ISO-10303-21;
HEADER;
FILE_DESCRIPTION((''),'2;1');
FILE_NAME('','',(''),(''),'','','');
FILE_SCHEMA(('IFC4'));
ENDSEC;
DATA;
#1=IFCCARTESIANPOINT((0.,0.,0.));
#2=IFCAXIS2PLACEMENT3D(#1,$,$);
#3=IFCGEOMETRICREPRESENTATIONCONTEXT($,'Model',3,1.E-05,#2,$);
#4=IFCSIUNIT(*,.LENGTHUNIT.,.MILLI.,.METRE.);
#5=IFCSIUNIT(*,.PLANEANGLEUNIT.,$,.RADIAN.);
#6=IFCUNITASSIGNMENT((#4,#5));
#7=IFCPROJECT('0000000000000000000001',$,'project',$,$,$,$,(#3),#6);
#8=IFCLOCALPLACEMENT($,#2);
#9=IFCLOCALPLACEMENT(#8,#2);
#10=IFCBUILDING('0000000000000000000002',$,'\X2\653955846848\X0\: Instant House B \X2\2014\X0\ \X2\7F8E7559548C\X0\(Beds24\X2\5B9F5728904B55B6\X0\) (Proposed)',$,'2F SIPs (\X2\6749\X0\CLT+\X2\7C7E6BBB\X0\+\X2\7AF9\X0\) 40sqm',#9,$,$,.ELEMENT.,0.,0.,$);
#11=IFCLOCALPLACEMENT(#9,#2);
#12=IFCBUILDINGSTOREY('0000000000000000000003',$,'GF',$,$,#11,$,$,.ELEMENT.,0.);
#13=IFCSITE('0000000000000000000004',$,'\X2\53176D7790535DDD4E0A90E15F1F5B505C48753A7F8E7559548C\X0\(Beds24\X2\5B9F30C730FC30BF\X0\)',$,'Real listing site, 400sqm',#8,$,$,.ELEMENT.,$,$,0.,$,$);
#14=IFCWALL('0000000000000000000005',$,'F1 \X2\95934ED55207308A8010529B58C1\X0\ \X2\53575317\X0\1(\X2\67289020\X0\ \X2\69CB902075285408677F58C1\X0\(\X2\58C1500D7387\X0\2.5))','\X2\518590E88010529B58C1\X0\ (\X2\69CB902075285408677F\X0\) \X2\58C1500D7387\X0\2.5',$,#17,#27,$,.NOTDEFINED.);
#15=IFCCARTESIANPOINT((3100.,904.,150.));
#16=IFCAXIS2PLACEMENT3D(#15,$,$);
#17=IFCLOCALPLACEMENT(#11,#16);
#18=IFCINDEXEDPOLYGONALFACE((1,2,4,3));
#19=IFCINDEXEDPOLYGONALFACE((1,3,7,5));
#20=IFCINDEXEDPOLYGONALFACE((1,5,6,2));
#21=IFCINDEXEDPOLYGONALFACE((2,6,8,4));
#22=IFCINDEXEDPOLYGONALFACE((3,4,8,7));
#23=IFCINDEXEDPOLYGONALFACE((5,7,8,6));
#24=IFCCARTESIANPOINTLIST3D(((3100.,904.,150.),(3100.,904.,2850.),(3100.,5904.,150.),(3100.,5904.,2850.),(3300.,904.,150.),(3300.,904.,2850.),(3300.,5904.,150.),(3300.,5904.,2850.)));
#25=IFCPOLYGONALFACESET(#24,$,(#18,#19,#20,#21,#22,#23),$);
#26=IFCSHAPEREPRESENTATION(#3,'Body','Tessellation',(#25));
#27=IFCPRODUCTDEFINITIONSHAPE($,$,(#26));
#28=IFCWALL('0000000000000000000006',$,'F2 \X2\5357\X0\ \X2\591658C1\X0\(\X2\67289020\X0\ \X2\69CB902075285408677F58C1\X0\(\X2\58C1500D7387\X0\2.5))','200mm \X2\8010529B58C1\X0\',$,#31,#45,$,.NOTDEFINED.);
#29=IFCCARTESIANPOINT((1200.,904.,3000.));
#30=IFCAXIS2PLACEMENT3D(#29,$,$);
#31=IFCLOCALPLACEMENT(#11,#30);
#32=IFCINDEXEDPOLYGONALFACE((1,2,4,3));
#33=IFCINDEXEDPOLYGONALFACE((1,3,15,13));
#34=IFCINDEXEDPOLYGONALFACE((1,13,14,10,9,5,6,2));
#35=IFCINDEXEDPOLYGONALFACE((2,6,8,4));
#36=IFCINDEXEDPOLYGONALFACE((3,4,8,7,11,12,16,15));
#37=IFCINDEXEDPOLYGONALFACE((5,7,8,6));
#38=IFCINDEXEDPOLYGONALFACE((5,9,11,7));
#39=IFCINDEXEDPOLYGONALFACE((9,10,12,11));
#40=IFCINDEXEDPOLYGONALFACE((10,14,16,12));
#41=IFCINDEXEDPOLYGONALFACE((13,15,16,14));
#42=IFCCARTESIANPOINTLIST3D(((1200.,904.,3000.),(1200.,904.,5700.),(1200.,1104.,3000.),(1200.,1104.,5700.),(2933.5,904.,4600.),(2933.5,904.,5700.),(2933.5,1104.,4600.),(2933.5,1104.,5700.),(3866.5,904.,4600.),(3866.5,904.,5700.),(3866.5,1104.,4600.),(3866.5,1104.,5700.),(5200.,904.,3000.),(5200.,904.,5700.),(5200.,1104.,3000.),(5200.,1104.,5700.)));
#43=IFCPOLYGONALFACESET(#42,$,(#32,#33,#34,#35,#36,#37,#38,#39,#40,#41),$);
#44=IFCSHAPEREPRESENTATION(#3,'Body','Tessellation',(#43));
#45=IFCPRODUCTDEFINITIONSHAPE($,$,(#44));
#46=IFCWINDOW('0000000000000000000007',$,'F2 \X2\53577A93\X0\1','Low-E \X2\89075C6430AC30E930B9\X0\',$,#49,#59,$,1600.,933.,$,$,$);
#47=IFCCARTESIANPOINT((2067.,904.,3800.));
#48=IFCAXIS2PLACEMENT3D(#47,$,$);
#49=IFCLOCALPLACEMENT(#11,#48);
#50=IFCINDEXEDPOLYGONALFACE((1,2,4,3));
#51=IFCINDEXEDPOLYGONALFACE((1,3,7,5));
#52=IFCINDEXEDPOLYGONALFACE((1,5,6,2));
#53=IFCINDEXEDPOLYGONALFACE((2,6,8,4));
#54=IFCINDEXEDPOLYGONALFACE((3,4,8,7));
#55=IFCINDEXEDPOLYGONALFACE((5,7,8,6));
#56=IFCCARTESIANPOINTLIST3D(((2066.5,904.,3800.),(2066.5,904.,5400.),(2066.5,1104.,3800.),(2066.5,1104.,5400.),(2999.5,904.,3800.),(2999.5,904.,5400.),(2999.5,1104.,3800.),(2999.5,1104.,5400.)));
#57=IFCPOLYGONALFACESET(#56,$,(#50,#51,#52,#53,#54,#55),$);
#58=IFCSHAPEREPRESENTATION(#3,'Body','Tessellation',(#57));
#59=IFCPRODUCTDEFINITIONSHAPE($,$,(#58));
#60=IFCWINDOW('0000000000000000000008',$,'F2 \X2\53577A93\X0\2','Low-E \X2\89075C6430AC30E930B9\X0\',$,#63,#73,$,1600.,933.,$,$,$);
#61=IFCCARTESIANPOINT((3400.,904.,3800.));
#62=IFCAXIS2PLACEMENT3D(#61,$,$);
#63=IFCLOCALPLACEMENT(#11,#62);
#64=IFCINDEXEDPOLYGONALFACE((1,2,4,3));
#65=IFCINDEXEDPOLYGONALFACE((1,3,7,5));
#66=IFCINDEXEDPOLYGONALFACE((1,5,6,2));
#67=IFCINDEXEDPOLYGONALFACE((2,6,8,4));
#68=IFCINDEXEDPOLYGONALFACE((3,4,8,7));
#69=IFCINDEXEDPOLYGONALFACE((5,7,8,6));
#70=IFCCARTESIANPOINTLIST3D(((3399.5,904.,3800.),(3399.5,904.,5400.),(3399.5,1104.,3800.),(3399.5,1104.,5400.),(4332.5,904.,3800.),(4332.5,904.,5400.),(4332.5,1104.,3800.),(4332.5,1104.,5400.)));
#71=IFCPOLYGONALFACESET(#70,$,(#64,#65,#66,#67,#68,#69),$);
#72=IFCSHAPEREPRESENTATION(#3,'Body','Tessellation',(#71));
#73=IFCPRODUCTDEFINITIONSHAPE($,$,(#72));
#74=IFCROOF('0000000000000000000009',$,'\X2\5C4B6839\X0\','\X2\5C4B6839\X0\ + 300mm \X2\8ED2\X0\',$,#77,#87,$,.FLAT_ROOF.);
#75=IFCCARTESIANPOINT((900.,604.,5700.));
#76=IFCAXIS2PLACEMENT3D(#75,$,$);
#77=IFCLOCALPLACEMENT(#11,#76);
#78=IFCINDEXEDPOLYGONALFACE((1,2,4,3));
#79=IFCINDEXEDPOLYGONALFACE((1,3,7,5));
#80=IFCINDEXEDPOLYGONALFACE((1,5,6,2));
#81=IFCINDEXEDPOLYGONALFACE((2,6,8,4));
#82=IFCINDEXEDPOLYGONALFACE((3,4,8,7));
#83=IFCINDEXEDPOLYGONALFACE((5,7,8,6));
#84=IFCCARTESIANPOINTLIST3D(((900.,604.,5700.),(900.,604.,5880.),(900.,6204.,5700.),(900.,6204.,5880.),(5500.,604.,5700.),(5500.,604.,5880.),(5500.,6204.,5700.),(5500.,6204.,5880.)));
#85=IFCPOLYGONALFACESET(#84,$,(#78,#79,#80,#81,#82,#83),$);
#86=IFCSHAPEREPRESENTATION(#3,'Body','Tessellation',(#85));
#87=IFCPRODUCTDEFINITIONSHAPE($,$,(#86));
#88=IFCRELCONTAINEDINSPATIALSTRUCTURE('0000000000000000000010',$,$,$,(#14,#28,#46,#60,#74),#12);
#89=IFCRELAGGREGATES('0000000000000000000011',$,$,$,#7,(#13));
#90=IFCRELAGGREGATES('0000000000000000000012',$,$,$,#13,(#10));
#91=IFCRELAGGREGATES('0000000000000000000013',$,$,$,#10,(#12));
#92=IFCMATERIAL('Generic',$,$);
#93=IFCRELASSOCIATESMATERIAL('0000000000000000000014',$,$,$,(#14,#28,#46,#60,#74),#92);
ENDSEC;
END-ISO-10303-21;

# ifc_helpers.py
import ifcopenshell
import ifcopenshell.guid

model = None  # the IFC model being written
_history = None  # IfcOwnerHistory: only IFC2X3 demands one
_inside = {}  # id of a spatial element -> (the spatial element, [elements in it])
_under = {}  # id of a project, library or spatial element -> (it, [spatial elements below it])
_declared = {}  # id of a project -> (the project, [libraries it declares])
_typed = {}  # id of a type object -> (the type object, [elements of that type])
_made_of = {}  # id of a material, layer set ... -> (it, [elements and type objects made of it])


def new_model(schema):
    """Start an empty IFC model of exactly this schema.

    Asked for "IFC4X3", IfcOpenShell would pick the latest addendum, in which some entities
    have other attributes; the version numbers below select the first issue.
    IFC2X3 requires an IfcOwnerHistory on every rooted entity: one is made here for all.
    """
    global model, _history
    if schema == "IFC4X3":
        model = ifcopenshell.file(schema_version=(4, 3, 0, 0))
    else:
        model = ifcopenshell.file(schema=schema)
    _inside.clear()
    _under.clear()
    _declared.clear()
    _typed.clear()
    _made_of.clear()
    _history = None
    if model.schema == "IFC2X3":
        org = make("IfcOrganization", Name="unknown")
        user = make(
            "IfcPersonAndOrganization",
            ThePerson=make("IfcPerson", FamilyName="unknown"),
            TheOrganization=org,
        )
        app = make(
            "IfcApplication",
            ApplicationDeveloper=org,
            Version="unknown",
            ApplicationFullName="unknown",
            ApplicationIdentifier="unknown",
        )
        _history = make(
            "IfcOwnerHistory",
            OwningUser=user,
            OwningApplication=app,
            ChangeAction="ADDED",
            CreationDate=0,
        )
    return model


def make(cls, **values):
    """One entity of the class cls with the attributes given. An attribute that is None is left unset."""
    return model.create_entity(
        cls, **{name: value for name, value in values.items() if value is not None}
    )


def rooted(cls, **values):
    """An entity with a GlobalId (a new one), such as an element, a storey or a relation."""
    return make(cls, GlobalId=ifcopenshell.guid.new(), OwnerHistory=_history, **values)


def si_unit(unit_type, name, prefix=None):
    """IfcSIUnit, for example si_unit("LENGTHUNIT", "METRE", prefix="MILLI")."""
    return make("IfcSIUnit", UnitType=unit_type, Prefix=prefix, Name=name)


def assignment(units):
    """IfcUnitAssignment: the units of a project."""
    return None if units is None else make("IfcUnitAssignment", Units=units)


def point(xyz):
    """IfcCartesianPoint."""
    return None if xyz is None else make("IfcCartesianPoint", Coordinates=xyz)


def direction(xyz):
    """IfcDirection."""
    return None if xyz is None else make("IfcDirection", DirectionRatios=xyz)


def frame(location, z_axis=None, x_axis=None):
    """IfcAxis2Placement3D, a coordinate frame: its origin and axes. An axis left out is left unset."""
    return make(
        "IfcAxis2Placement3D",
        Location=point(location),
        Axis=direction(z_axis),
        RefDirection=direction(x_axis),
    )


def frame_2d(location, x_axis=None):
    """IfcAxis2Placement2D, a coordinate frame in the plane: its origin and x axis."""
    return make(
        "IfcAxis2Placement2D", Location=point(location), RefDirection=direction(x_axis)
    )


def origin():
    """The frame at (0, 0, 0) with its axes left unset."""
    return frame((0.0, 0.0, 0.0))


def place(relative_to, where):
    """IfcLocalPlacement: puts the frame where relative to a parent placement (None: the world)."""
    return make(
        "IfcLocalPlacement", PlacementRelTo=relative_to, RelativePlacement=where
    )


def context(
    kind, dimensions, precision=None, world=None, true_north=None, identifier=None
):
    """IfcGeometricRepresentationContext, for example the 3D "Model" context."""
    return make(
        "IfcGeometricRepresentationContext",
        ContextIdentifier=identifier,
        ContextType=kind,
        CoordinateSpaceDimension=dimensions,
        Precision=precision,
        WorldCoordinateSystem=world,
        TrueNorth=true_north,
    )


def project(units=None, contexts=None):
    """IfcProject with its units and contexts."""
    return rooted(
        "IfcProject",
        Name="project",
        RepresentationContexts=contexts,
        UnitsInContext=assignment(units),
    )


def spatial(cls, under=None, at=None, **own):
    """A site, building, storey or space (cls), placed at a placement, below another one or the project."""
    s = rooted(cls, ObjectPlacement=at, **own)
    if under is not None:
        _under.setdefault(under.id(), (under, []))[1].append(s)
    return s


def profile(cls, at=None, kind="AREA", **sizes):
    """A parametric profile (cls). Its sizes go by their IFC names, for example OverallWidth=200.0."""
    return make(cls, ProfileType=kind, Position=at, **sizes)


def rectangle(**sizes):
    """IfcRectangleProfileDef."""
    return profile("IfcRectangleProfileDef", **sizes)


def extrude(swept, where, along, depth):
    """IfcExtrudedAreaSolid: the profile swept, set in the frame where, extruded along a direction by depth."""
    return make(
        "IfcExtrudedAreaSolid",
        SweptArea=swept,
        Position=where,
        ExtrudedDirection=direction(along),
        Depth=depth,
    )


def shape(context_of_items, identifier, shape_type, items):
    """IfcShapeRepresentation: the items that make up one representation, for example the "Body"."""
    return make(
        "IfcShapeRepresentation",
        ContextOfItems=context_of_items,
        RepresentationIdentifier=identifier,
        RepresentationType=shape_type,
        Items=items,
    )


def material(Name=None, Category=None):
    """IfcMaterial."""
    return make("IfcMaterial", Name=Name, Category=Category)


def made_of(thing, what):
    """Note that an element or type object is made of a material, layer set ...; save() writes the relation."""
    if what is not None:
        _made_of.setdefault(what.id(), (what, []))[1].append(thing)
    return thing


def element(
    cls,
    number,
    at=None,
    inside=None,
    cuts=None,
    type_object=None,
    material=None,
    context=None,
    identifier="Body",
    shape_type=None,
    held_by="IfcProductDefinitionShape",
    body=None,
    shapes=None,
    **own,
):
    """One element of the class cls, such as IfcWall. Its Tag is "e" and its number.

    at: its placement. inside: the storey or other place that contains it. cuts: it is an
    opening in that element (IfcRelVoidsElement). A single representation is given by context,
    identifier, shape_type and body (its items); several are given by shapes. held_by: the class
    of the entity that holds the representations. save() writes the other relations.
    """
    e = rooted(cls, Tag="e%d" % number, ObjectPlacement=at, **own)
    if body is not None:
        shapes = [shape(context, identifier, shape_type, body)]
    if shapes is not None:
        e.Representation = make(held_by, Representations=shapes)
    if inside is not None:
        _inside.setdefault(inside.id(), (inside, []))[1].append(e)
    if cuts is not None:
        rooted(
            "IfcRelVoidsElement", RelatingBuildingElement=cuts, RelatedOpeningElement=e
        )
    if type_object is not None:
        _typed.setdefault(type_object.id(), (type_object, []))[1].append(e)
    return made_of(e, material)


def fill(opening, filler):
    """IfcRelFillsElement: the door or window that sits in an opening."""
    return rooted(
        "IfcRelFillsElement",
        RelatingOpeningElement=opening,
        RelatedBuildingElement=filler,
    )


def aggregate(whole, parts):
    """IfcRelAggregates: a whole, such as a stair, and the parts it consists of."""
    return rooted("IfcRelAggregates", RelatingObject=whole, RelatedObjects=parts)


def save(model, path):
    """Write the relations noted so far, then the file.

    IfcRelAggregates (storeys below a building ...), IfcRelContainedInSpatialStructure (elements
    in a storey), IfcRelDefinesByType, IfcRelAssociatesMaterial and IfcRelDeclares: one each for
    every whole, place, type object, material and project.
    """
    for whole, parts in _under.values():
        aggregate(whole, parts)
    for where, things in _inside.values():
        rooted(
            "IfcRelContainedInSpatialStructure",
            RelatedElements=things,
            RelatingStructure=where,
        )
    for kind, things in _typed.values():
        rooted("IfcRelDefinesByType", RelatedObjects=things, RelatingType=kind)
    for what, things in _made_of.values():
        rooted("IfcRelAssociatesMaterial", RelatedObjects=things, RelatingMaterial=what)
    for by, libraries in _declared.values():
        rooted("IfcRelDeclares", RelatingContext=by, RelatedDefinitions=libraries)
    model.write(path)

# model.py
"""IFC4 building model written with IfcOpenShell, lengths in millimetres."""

from ifc_helpers import new_model, si_unit, frame, frame_2d, origin, place, context, project, spatial, rectangle, extrude, material, element, fill, save


model = new_model("IFC4")

# Units and contexts
model_context = context("Model", 3, precision=1e-05, world=origin())
ifc_project = project(units=[si_unit("LENGTHUNIT", "METRE", prefix="MILLI"), si_unit("PLANEANGLEUNIT", "RADIAN")], contexts=[model_context])

# Site, building, storey
site_placement = place(None, origin())
site = spatial("IfcSite", under=ifc_project, at=site_placement, Name="北海道川上郡弟子屈町美留和(Beds24実データ)", ObjectType="Real listing site, 400sqm", CompositionType="ELEMENT", RefElevation=0.0)
building_placement = place(site_placement, origin())
building = spatial("IfcBuilding", under=site, at=building_placement, Name="改善案: Instant House B — 美留和(Beds24実在運営) (Proposed)", ObjectType="2F SIPs (杉CLT+籾殻+竹) 40sqm", CompositionType="ELEMENT", ElevationOfRefHeight=0.0, ElevationOfTerrain=0.0)
storey_placement = place(building_placement, origin())
storey = spatial("IfcBuildingStorey", under=building, at=storey_placement, Name="GF", CompositionType="ELEMENT", Elevation=0.0)

# Shared definitions
ifc_material_1 = material(Name="Generic")

# Wall
wall_1_placement = place(storey_placement, frame((3100.0, 904.0, 150.0)))
element("IfcWall", 1, at=wall_1_placement, inside=storey, material=ifc_material_1, Name="F1 間仕切り耐力壁 南北1(木造 構造用合板壁(壁倍率2.5))", Description="内部耐力壁 (構造用合板) 壁倍率2.5", PredefinedType="NOTDEFINED", context=model_context, shape_type="SweptSolid", body=[
    extrude(rectangle(XDim=200.0, YDim=5000.0, at=frame_2d((100.0, 2500.0))), frame((3100.0, 904.0, 150.0)), (0.0, 0.0, 1.0), 2700.0),
])

# Wall, openings, windows
wall_2_placement = place(storey_placement, frame((1200.0, 904.0, 3000.0)))
wall_2 = element("IfcWall", 2, at=wall_2_placement, inside=storey, material=ifc_material_1, Name="F2 南 外壁(木造 構造用合板壁(壁倍率2.5))", Description="200mm 耐力壁", PredefinedType="NOTDEFINED", context=model_context, shape_type="SweptSolid", body=[
    extrude(rectangle(XDim=4000.0, YDim=200.0, at=frame_2d((2000.0, 100.0))), frame((1200.0, 904.0, 3000.0)), (0.0, 0.0, 1.0), 2700.0),
])
opening_1_placement = place(storey_placement, frame((2067.0, 904.0, 3800.0)))
opening_1 = element("IfcOpeningElement", 3, at=opening_1_placement, cuts=wall_2, PredefinedType="NOTDEFINED", context=model_context, shape_type="SweptSolid", body=[
    extrude(rectangle(XDim=933.0, YDim=200.0, at=frame_2d((466.0, 100.0))), frame((2067.0, 904.0, 3800.0)), (0.0, 0.0, 1.0), 1600.0),
])
opening_2_placement = place(storey_placement, frame((3400.0, 904.0, 3800.0)))
opening_2 = element("IfcOpeningElement", 4, at=opening_2_placement, cuts=wall_2, PredefinedType="NOTDEFINED", context=model_context, shape_type="SweptSolid", body=[
    extrude(rectangle(XDim=933.0, YDim=200.0, at=frame_2d((466.0, 100.0))), frame((3400.0, 904.0, 3800.0)), (0.0, 0.0, 1.0), 1600.0),
])
window_1_placement = place(storey_placement, frame((2067.0, 904.0, 3800.0)))
window_1 = element("IfcWindow", 5, at=window_1_placement, inside=storey, material=ifc_material_1, Name="F2 南窓1", Description="Low-E 複層ガラス", OverallHeight=1600.0, OverallWidth=933.0, context=model_context, shape_type="SweptSolid", body=[
    extrude(rectangle(XDim=933.0, YDim=200.0, at=frame_2d((466.0, 100.0))), frame((2067.0, 904.0, 3800.0)), (0.0, 0.0, 1.0), 1600.0),
])
fill(opening_1, window_1)
window_2_placement = place(storey_placement, frame((3400.0, 904.0, 3800.0)))
window_2 = element("IfcWindow", 6, at=window_2_placement, inside=storey, material=ifc_material_1, Name="F2 南窓2", Description="Low-E 複層ガラス", OverallHeight=1600.0, OverallWidth=933.0, context=model_context, shape_type="SweptSolid", body=[
    extrude(rectangle(XDim=933.0, YDim=200.0, at=frame_2d((466.0, 100.0))), frame((3400.0, 904.0, 3800.0)), (0.0, 0.0, 1.0), 1600.0),
])
fill(opening_2, window_2)

# Roof
roof_placement = place(storey_placement, frame((900.0, 604.0, 5700.0)))
element("IfcRoof", 7, at=roof_placement, inside=storey, material=ifc_material_1, Name="屋根", Description="屋根 + 300mm 軒", PredefinedType="FLAT_ROOF", context=model_context, shape_type="SweptSolid", body=[
    extrude(rectangle(XDim=4600.0, YDim=5600.0, at=frame_2d((2300.0, 2800.0))), frame((900.0, 604.0, 5700.0)), (0.0, 0.0, 1.0), 180.0),
])

save(model, "model.ifc")
